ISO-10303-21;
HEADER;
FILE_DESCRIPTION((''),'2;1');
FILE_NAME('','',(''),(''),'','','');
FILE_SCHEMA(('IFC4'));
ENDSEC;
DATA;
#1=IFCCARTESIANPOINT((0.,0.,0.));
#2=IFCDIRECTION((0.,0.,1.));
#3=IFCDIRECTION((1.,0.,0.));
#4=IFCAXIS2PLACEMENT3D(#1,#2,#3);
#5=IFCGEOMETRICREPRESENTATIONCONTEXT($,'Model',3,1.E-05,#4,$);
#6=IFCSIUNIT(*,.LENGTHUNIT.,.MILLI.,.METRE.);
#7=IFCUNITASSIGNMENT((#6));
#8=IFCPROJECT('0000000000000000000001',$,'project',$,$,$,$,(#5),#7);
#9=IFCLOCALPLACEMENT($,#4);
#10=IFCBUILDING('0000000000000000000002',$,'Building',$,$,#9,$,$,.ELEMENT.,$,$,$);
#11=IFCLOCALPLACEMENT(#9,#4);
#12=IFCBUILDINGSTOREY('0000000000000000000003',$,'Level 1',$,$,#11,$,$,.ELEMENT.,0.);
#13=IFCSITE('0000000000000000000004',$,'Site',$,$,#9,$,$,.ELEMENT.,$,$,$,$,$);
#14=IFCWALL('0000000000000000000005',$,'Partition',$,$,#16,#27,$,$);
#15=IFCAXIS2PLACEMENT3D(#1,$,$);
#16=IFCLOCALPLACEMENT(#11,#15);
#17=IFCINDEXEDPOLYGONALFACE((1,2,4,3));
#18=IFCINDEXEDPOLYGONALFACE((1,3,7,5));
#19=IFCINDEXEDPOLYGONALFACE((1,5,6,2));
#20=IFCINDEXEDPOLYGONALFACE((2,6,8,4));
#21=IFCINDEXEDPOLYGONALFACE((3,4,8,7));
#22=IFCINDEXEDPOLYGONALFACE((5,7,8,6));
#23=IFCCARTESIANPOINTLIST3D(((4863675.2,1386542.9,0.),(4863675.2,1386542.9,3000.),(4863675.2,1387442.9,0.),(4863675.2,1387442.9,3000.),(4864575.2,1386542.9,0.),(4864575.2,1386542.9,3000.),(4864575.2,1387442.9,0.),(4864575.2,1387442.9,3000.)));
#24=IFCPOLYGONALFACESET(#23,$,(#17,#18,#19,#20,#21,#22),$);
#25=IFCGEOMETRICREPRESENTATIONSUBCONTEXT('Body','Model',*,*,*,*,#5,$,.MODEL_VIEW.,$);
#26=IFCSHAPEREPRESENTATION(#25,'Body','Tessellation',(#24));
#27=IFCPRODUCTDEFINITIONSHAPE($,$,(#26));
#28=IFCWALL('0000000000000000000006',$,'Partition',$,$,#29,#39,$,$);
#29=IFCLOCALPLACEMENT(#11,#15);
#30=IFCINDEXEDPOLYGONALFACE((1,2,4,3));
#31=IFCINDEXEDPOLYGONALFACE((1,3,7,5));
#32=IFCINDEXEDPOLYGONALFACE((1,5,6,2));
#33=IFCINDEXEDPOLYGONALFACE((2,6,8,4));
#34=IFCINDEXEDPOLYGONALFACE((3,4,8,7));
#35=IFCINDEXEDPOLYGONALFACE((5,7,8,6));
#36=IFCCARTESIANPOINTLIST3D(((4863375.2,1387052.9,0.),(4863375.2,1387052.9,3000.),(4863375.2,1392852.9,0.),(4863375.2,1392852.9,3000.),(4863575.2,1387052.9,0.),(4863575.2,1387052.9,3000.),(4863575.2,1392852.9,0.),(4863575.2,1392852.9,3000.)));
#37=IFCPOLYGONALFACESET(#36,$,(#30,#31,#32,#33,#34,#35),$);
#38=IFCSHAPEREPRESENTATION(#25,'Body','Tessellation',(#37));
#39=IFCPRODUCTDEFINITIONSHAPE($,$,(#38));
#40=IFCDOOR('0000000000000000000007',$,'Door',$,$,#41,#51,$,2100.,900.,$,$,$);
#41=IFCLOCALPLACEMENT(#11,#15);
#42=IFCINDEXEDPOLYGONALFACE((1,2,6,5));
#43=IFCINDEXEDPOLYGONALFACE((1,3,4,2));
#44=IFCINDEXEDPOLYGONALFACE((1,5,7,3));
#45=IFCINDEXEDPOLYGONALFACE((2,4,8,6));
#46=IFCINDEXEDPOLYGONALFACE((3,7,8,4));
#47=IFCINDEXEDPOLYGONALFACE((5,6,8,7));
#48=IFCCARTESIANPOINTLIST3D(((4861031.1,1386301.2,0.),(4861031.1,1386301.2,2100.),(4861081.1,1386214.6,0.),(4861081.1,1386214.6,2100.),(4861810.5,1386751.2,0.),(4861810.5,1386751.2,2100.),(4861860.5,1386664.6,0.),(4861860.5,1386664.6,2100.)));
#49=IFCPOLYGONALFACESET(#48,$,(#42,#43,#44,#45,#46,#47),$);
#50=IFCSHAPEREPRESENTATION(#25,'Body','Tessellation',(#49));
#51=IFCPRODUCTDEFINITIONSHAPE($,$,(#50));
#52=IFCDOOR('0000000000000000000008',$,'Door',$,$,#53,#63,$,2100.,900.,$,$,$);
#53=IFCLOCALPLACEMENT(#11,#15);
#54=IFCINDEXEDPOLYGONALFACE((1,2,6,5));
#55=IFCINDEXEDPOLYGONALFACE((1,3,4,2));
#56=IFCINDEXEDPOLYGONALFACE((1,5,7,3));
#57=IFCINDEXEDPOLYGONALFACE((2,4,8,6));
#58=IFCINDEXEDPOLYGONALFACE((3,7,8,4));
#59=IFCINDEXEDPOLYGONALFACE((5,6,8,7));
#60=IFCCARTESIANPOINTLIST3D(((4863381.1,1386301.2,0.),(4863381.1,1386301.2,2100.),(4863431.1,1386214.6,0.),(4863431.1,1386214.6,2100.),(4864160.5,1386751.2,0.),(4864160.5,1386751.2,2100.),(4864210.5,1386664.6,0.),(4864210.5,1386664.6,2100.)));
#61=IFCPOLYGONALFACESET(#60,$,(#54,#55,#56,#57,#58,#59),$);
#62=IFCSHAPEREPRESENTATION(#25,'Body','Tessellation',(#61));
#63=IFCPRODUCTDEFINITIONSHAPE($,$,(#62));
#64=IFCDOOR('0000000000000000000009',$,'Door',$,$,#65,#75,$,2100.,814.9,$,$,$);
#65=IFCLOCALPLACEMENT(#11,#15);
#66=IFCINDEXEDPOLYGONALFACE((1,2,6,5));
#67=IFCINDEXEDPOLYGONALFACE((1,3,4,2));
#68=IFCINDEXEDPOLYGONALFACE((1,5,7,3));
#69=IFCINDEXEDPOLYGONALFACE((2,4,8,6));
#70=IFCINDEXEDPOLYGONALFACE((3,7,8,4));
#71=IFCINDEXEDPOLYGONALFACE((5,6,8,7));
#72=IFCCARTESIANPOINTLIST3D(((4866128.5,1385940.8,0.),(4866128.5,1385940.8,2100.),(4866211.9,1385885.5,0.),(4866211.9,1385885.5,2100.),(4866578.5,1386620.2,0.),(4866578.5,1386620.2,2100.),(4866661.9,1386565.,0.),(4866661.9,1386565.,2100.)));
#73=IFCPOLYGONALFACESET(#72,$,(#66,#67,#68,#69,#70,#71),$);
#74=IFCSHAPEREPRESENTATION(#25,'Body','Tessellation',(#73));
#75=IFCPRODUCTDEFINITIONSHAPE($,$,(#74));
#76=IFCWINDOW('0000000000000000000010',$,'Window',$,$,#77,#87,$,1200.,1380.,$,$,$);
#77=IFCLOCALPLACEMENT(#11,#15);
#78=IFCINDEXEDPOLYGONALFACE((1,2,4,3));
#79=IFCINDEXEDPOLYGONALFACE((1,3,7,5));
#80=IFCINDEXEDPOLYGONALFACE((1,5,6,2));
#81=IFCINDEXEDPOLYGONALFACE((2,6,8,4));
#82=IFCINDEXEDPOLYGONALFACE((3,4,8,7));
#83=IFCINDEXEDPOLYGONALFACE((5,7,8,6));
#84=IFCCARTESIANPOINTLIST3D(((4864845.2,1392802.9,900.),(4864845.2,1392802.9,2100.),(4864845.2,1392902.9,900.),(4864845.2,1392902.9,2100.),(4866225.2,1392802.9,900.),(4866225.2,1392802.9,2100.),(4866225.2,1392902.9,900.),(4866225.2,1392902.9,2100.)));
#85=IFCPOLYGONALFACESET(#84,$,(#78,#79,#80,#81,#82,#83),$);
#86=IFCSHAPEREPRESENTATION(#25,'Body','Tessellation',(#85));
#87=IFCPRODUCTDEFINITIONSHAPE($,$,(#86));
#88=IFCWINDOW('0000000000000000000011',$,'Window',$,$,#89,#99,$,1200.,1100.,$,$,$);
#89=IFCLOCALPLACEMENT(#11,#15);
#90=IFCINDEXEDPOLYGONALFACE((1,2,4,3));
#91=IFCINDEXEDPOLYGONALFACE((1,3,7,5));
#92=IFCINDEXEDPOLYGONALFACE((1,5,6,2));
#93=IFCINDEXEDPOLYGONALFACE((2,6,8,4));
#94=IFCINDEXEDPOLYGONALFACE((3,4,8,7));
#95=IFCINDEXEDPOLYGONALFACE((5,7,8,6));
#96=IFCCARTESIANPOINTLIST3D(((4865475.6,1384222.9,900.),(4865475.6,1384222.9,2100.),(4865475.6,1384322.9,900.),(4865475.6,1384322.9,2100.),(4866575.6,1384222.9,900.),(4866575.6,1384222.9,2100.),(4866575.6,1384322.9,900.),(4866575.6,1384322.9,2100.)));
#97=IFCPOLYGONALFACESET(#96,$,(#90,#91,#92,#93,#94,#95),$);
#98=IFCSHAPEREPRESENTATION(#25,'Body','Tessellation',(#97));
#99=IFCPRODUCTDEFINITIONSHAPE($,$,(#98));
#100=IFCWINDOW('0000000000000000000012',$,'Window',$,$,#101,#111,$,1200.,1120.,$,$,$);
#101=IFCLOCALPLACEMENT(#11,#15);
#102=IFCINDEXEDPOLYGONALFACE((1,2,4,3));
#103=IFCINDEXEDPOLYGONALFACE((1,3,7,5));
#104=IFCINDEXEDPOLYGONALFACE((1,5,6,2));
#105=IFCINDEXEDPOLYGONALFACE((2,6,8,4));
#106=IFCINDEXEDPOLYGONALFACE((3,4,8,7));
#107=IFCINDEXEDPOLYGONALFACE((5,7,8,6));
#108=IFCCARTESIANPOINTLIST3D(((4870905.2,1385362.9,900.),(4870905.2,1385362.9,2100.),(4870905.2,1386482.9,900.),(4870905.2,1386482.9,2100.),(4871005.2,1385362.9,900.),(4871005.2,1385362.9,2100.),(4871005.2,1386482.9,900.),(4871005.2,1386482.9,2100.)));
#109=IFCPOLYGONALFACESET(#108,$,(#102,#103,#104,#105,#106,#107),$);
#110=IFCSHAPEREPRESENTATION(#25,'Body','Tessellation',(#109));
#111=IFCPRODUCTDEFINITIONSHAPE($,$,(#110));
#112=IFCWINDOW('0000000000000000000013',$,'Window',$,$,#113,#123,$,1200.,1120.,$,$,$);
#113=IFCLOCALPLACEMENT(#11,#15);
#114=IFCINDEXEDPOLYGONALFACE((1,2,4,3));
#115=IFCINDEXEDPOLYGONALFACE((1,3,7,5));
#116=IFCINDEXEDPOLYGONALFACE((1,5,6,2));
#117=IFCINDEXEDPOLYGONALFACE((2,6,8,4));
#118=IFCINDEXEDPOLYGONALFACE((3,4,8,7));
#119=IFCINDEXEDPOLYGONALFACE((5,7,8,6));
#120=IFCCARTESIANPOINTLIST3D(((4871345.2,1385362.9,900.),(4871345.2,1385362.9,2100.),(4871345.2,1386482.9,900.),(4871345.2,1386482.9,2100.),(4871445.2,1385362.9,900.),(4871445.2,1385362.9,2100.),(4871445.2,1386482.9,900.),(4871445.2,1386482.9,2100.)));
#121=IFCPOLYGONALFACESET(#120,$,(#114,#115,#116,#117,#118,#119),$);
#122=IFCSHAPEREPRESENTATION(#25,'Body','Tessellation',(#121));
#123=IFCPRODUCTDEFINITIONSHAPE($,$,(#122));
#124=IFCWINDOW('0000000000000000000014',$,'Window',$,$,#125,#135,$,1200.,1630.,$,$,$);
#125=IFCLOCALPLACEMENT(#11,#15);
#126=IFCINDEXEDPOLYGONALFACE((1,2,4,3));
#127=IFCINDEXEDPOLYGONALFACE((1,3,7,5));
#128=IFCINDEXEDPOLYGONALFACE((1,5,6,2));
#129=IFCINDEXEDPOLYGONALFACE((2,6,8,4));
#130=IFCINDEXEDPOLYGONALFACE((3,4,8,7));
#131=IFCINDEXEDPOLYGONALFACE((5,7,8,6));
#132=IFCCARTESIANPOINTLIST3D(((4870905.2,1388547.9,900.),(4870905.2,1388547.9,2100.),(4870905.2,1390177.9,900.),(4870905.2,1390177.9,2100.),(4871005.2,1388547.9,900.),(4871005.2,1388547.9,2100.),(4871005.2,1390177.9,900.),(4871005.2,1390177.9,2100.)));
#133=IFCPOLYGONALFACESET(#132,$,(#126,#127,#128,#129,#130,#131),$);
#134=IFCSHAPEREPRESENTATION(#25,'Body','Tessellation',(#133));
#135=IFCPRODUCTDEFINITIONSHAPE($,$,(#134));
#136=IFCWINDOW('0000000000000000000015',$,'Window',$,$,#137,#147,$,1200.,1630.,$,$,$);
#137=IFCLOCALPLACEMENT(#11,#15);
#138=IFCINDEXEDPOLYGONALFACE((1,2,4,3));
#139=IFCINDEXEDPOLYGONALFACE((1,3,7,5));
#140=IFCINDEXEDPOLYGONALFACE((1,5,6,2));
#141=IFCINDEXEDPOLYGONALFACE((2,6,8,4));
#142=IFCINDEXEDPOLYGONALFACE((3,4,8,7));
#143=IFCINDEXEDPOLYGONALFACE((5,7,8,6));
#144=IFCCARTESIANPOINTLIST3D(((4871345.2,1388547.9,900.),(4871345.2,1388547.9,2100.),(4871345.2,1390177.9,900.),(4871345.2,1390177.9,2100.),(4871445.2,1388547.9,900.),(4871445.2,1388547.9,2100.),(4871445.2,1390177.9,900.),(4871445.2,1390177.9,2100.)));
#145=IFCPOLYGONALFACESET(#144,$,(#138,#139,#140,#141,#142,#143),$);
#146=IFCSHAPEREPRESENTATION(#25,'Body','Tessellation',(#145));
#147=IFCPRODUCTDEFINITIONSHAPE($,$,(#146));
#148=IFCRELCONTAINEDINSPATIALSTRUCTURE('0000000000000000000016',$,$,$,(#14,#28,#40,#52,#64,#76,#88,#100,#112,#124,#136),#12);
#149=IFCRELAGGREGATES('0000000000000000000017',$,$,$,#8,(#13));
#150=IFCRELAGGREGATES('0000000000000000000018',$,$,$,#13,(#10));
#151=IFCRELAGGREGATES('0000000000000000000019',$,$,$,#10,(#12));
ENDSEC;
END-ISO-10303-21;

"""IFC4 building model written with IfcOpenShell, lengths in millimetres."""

from ifc_helpers import new_model, si_unit, frame, frame_2d, origin_with_axes, place, context, subcontext, project, spatial, rectangle, extrude, element, save


model = new_model("IFC4")

# Units and contexts
model_context = context("Model", 3, precision=1e-05, world=origin_with_axes())
body_context = subcontext(model_context, "Body", "Model", "MODEL_VIEW")
ifc_project = project(units=[si_unit("LENGTHUNIT", "METRE", prefix="MILLI")], contexts=[model_context])

# Site, building, storey
placement = place(None, origin_with_axes())
site = spatial("IfcSite", under=ifc_project, at=placement, Name="Site", CompositionType="ELEMENT")
building = spatial("IfcBuilding", under=site, at=placement, Name="Building", CompositionType="ELEMENT")
storey_placement = place(placement, origin_with_axes())
storey = spatial("IfcBuildingStorey", under=building, at=storey_placement, Name="Level 1", CompositionType="ELEMENT", Elevation=0.0)

# Walls
wall_1_placement = place(placement, frame((4863675.2, 1386992.9, 0.0), z_axis=(0.0, 0.0, 1.0), x_axis=(1.0, 0.0, 0.0)))
element("IfcWall", 1, at=wall_1_placement, inside=storey, Name="Partition", context=body_context, shape_type="SweptSolid", body=[
    extrude(rectangle(XDim=900.0, YDim=900.0, at=frame_2d((450.0, 0.0), x_axis=(1.0, 0.0))), origin_with_axes(), (0.0, 0.0, 1.0), 3000.0),
])
wall_2_placement = place(placement, frame((4863475.2, 1387052.9, 0.0), z_axis=(0.0, 0.0, 1.0), x_axis=(0.0, 1.0, 0.0)))
element("IfcWall", 2, at=wall_2_placement, inside=storey, Name="Partition", context=body_context, shape_type="SweptSolid", body=[
    extrude(rectangle(XDim=5800.0, YDim=200.0, at=frame_2d((2900.0, 0.0), x_axis=(1.0, 0.0))), origin_with_axes(), (0.0, 0.0, 1.0), 3000.0),
])

# Doors
door_1_placement = place(placement, frame((4861835.5, 1386707.9, 0.0), z_axis=(0.0, 0.0, 1.0), x_axis=(-0.866025, -0.5, 0.0)))
element("IfcDoor", 3, at=door_1_placement, inside=storey, Name="Door", OverallHeight=2100.0, OverallWidth=900.0, context=body_context, shape_type="SweptSolid", body=[
    extrude(rectangle(XDim=900.0, YDim=100.0, at=frame_2d((450.0, 0.0), x_axis=(1.0, 0.0))), origin_with_axes(), (0.0, 0.0, 1.0), 2100.0),
])
door_2_placement = place(placement, frame((4864185.5, 1386707.9, 0.0), z_axis=(0.0, 0.0, 1.0), x_axis=(-0.866025, -0.5, 0.0)))
element("IfcDoor", 4, at=door_2_placement, inside=storey, Name="Door", OverallHeight=2100.0, OverallWidth=900.0, context=body_context, shape_type="SweptSolid", body=[
    extrude(rectangle(XDim=900.0, YDim=100.0, at=frame_2d((450.0, 0.0), x_axis=(1.0, 0.0))), origin_with_axes(), (0.0, 0.0, 1.0), 2100.0),
])
door_3_placement = place(placement, frame((4866170.2, 1385913.2, 0.0), z_axis=(0.0, 0.0, 1.0), x_axis=(0.552193, 0.833716, 0.0)))
element("IfcDoor", 5, at=door_3_placement, inside=storey, Name="Door", OverallHeight=2100.0, OverallWidth=814.9, context=body_context, shape_type="SweptSolid", body=[
    extrude(rectangle(XDim=814.9, YDim=100.0, at=frame_2d((407.5, 0.0), x_axis=(1.0, 0.0))), origin_with_axes(), (0.0, 0.0, 1.0), 2100.0),
])

# Windows
window_1_placement = place(placement, frame((4864845.2, 1392852.9, 900.0), z_axis=(0.0, 0.0, 1.0), x_axis=(1.0, 0.0, 0.0)))
element("IfcWindow", 6, at=window_1_placement, inside=storey, Name="Window", OverallHeight=1200.0, OverallWidth=1380.0, context=body_context, shape_type="SweptSolid", body=[
    extrude(rectangle(XDim=1380.0, YDim=100.0, at=frame_2d((690.0, 0.0), x_axis=(1.0, 0.0))), origin_with_axes(), (0.0, 0.0, 1.0), 1200.0),
])
window_2_placement = place(placement, frame((4865475.6, 1384272.9, 900.0), z_axis=(0.0, 0.0, 1.0), x_axis=(1.0, 0.0, 0.0)))
element("IfcWindow", 7, at=window_2_placement, inside=storey, Name="Window", OverallHeight=1200.0, OverallWidth=1100.0, context=body_context, shape_type="SweptSolid", body=[
    extrude(rectangle(XDim=1100.0, YDim=100.0, at=frame_2d((550.0, 0.0), x_axis=(1.0, 0.0))), origin_with_axes(), (0.0, 0.0, 1.0), 1200.0),
])
window_3_placement = place(placement, frame((4870955.2, 1386482.9, 900.0), z_axis=(0.0, 0.0, 1.0), x_axis=(0.0, -1.0, 0.0)))
element("IfcWindow", 8, at=window_3_placement, inside=storey, Name="Window", OverallHeight=1200.0, OverallWidth=1120.0, context=body_context, shape_type="SweptSolid", body=[
    extrude(rectangle(XDim=1120.0, YDim=100.0, at=frame_2d((560.0, 0.0), x_axis=(1.0, 0.0))), origin_with_axes(), (0.0, 0.0, 1.0), 1200.0),
])
window_4_placement = place(placement, frame((4871395.2, 1386482.9, 900.0), z_axis=(0.0, 0.0, 1.0), x_axis=(0.0, -1.0, 0.0)))
element("IfcWindow", 9, at=window_4_placement, inside=storey, Name="Window", OverallHeight=1200.0, OverallWidth=1120.0, context=body_context, shape_type="SweptSolid", body=[
    extrude(rectangle(XDim=1120.0, YDim=100.0, at=frame_2d((560.0, 0.0), x_axis=(1.0, 0.0))), origin_with_axes(), (0.0, 0.0, 1.0), 1200.0),
])
for number, where, z_axis, x_axis, name in (
    (10, (4870955.2, 1390177.9, 900.0), (0.0, 0.0, 1.0), (0.0, -1.0, 0.0), "Window"),
    (11, (4871395.2, 1390177.9, 900.0), (0.0, 0.0, 1.0), (0.0, -1.0, 0.0), "Window"),
):
    element("IfcWindow", number, at=place(placement, frame(where, z_axis=z_axis, x_axis=x_axis)), inside=storey, Name=name, OverallHeight=1200.0, OverallWidth=1630.0, context=body_context, shape_type="SweptSolid", body=[
        extrude(rectangle(XDim=1630.0, YDim=100.0, at=frame_2d((815.0, 0.0), x_axis=(1.0, 0.0))), origin_with_axes(), (0.0, 0.0, 1.0), 1200.0),
    ])

save(model, "model.ifc")
